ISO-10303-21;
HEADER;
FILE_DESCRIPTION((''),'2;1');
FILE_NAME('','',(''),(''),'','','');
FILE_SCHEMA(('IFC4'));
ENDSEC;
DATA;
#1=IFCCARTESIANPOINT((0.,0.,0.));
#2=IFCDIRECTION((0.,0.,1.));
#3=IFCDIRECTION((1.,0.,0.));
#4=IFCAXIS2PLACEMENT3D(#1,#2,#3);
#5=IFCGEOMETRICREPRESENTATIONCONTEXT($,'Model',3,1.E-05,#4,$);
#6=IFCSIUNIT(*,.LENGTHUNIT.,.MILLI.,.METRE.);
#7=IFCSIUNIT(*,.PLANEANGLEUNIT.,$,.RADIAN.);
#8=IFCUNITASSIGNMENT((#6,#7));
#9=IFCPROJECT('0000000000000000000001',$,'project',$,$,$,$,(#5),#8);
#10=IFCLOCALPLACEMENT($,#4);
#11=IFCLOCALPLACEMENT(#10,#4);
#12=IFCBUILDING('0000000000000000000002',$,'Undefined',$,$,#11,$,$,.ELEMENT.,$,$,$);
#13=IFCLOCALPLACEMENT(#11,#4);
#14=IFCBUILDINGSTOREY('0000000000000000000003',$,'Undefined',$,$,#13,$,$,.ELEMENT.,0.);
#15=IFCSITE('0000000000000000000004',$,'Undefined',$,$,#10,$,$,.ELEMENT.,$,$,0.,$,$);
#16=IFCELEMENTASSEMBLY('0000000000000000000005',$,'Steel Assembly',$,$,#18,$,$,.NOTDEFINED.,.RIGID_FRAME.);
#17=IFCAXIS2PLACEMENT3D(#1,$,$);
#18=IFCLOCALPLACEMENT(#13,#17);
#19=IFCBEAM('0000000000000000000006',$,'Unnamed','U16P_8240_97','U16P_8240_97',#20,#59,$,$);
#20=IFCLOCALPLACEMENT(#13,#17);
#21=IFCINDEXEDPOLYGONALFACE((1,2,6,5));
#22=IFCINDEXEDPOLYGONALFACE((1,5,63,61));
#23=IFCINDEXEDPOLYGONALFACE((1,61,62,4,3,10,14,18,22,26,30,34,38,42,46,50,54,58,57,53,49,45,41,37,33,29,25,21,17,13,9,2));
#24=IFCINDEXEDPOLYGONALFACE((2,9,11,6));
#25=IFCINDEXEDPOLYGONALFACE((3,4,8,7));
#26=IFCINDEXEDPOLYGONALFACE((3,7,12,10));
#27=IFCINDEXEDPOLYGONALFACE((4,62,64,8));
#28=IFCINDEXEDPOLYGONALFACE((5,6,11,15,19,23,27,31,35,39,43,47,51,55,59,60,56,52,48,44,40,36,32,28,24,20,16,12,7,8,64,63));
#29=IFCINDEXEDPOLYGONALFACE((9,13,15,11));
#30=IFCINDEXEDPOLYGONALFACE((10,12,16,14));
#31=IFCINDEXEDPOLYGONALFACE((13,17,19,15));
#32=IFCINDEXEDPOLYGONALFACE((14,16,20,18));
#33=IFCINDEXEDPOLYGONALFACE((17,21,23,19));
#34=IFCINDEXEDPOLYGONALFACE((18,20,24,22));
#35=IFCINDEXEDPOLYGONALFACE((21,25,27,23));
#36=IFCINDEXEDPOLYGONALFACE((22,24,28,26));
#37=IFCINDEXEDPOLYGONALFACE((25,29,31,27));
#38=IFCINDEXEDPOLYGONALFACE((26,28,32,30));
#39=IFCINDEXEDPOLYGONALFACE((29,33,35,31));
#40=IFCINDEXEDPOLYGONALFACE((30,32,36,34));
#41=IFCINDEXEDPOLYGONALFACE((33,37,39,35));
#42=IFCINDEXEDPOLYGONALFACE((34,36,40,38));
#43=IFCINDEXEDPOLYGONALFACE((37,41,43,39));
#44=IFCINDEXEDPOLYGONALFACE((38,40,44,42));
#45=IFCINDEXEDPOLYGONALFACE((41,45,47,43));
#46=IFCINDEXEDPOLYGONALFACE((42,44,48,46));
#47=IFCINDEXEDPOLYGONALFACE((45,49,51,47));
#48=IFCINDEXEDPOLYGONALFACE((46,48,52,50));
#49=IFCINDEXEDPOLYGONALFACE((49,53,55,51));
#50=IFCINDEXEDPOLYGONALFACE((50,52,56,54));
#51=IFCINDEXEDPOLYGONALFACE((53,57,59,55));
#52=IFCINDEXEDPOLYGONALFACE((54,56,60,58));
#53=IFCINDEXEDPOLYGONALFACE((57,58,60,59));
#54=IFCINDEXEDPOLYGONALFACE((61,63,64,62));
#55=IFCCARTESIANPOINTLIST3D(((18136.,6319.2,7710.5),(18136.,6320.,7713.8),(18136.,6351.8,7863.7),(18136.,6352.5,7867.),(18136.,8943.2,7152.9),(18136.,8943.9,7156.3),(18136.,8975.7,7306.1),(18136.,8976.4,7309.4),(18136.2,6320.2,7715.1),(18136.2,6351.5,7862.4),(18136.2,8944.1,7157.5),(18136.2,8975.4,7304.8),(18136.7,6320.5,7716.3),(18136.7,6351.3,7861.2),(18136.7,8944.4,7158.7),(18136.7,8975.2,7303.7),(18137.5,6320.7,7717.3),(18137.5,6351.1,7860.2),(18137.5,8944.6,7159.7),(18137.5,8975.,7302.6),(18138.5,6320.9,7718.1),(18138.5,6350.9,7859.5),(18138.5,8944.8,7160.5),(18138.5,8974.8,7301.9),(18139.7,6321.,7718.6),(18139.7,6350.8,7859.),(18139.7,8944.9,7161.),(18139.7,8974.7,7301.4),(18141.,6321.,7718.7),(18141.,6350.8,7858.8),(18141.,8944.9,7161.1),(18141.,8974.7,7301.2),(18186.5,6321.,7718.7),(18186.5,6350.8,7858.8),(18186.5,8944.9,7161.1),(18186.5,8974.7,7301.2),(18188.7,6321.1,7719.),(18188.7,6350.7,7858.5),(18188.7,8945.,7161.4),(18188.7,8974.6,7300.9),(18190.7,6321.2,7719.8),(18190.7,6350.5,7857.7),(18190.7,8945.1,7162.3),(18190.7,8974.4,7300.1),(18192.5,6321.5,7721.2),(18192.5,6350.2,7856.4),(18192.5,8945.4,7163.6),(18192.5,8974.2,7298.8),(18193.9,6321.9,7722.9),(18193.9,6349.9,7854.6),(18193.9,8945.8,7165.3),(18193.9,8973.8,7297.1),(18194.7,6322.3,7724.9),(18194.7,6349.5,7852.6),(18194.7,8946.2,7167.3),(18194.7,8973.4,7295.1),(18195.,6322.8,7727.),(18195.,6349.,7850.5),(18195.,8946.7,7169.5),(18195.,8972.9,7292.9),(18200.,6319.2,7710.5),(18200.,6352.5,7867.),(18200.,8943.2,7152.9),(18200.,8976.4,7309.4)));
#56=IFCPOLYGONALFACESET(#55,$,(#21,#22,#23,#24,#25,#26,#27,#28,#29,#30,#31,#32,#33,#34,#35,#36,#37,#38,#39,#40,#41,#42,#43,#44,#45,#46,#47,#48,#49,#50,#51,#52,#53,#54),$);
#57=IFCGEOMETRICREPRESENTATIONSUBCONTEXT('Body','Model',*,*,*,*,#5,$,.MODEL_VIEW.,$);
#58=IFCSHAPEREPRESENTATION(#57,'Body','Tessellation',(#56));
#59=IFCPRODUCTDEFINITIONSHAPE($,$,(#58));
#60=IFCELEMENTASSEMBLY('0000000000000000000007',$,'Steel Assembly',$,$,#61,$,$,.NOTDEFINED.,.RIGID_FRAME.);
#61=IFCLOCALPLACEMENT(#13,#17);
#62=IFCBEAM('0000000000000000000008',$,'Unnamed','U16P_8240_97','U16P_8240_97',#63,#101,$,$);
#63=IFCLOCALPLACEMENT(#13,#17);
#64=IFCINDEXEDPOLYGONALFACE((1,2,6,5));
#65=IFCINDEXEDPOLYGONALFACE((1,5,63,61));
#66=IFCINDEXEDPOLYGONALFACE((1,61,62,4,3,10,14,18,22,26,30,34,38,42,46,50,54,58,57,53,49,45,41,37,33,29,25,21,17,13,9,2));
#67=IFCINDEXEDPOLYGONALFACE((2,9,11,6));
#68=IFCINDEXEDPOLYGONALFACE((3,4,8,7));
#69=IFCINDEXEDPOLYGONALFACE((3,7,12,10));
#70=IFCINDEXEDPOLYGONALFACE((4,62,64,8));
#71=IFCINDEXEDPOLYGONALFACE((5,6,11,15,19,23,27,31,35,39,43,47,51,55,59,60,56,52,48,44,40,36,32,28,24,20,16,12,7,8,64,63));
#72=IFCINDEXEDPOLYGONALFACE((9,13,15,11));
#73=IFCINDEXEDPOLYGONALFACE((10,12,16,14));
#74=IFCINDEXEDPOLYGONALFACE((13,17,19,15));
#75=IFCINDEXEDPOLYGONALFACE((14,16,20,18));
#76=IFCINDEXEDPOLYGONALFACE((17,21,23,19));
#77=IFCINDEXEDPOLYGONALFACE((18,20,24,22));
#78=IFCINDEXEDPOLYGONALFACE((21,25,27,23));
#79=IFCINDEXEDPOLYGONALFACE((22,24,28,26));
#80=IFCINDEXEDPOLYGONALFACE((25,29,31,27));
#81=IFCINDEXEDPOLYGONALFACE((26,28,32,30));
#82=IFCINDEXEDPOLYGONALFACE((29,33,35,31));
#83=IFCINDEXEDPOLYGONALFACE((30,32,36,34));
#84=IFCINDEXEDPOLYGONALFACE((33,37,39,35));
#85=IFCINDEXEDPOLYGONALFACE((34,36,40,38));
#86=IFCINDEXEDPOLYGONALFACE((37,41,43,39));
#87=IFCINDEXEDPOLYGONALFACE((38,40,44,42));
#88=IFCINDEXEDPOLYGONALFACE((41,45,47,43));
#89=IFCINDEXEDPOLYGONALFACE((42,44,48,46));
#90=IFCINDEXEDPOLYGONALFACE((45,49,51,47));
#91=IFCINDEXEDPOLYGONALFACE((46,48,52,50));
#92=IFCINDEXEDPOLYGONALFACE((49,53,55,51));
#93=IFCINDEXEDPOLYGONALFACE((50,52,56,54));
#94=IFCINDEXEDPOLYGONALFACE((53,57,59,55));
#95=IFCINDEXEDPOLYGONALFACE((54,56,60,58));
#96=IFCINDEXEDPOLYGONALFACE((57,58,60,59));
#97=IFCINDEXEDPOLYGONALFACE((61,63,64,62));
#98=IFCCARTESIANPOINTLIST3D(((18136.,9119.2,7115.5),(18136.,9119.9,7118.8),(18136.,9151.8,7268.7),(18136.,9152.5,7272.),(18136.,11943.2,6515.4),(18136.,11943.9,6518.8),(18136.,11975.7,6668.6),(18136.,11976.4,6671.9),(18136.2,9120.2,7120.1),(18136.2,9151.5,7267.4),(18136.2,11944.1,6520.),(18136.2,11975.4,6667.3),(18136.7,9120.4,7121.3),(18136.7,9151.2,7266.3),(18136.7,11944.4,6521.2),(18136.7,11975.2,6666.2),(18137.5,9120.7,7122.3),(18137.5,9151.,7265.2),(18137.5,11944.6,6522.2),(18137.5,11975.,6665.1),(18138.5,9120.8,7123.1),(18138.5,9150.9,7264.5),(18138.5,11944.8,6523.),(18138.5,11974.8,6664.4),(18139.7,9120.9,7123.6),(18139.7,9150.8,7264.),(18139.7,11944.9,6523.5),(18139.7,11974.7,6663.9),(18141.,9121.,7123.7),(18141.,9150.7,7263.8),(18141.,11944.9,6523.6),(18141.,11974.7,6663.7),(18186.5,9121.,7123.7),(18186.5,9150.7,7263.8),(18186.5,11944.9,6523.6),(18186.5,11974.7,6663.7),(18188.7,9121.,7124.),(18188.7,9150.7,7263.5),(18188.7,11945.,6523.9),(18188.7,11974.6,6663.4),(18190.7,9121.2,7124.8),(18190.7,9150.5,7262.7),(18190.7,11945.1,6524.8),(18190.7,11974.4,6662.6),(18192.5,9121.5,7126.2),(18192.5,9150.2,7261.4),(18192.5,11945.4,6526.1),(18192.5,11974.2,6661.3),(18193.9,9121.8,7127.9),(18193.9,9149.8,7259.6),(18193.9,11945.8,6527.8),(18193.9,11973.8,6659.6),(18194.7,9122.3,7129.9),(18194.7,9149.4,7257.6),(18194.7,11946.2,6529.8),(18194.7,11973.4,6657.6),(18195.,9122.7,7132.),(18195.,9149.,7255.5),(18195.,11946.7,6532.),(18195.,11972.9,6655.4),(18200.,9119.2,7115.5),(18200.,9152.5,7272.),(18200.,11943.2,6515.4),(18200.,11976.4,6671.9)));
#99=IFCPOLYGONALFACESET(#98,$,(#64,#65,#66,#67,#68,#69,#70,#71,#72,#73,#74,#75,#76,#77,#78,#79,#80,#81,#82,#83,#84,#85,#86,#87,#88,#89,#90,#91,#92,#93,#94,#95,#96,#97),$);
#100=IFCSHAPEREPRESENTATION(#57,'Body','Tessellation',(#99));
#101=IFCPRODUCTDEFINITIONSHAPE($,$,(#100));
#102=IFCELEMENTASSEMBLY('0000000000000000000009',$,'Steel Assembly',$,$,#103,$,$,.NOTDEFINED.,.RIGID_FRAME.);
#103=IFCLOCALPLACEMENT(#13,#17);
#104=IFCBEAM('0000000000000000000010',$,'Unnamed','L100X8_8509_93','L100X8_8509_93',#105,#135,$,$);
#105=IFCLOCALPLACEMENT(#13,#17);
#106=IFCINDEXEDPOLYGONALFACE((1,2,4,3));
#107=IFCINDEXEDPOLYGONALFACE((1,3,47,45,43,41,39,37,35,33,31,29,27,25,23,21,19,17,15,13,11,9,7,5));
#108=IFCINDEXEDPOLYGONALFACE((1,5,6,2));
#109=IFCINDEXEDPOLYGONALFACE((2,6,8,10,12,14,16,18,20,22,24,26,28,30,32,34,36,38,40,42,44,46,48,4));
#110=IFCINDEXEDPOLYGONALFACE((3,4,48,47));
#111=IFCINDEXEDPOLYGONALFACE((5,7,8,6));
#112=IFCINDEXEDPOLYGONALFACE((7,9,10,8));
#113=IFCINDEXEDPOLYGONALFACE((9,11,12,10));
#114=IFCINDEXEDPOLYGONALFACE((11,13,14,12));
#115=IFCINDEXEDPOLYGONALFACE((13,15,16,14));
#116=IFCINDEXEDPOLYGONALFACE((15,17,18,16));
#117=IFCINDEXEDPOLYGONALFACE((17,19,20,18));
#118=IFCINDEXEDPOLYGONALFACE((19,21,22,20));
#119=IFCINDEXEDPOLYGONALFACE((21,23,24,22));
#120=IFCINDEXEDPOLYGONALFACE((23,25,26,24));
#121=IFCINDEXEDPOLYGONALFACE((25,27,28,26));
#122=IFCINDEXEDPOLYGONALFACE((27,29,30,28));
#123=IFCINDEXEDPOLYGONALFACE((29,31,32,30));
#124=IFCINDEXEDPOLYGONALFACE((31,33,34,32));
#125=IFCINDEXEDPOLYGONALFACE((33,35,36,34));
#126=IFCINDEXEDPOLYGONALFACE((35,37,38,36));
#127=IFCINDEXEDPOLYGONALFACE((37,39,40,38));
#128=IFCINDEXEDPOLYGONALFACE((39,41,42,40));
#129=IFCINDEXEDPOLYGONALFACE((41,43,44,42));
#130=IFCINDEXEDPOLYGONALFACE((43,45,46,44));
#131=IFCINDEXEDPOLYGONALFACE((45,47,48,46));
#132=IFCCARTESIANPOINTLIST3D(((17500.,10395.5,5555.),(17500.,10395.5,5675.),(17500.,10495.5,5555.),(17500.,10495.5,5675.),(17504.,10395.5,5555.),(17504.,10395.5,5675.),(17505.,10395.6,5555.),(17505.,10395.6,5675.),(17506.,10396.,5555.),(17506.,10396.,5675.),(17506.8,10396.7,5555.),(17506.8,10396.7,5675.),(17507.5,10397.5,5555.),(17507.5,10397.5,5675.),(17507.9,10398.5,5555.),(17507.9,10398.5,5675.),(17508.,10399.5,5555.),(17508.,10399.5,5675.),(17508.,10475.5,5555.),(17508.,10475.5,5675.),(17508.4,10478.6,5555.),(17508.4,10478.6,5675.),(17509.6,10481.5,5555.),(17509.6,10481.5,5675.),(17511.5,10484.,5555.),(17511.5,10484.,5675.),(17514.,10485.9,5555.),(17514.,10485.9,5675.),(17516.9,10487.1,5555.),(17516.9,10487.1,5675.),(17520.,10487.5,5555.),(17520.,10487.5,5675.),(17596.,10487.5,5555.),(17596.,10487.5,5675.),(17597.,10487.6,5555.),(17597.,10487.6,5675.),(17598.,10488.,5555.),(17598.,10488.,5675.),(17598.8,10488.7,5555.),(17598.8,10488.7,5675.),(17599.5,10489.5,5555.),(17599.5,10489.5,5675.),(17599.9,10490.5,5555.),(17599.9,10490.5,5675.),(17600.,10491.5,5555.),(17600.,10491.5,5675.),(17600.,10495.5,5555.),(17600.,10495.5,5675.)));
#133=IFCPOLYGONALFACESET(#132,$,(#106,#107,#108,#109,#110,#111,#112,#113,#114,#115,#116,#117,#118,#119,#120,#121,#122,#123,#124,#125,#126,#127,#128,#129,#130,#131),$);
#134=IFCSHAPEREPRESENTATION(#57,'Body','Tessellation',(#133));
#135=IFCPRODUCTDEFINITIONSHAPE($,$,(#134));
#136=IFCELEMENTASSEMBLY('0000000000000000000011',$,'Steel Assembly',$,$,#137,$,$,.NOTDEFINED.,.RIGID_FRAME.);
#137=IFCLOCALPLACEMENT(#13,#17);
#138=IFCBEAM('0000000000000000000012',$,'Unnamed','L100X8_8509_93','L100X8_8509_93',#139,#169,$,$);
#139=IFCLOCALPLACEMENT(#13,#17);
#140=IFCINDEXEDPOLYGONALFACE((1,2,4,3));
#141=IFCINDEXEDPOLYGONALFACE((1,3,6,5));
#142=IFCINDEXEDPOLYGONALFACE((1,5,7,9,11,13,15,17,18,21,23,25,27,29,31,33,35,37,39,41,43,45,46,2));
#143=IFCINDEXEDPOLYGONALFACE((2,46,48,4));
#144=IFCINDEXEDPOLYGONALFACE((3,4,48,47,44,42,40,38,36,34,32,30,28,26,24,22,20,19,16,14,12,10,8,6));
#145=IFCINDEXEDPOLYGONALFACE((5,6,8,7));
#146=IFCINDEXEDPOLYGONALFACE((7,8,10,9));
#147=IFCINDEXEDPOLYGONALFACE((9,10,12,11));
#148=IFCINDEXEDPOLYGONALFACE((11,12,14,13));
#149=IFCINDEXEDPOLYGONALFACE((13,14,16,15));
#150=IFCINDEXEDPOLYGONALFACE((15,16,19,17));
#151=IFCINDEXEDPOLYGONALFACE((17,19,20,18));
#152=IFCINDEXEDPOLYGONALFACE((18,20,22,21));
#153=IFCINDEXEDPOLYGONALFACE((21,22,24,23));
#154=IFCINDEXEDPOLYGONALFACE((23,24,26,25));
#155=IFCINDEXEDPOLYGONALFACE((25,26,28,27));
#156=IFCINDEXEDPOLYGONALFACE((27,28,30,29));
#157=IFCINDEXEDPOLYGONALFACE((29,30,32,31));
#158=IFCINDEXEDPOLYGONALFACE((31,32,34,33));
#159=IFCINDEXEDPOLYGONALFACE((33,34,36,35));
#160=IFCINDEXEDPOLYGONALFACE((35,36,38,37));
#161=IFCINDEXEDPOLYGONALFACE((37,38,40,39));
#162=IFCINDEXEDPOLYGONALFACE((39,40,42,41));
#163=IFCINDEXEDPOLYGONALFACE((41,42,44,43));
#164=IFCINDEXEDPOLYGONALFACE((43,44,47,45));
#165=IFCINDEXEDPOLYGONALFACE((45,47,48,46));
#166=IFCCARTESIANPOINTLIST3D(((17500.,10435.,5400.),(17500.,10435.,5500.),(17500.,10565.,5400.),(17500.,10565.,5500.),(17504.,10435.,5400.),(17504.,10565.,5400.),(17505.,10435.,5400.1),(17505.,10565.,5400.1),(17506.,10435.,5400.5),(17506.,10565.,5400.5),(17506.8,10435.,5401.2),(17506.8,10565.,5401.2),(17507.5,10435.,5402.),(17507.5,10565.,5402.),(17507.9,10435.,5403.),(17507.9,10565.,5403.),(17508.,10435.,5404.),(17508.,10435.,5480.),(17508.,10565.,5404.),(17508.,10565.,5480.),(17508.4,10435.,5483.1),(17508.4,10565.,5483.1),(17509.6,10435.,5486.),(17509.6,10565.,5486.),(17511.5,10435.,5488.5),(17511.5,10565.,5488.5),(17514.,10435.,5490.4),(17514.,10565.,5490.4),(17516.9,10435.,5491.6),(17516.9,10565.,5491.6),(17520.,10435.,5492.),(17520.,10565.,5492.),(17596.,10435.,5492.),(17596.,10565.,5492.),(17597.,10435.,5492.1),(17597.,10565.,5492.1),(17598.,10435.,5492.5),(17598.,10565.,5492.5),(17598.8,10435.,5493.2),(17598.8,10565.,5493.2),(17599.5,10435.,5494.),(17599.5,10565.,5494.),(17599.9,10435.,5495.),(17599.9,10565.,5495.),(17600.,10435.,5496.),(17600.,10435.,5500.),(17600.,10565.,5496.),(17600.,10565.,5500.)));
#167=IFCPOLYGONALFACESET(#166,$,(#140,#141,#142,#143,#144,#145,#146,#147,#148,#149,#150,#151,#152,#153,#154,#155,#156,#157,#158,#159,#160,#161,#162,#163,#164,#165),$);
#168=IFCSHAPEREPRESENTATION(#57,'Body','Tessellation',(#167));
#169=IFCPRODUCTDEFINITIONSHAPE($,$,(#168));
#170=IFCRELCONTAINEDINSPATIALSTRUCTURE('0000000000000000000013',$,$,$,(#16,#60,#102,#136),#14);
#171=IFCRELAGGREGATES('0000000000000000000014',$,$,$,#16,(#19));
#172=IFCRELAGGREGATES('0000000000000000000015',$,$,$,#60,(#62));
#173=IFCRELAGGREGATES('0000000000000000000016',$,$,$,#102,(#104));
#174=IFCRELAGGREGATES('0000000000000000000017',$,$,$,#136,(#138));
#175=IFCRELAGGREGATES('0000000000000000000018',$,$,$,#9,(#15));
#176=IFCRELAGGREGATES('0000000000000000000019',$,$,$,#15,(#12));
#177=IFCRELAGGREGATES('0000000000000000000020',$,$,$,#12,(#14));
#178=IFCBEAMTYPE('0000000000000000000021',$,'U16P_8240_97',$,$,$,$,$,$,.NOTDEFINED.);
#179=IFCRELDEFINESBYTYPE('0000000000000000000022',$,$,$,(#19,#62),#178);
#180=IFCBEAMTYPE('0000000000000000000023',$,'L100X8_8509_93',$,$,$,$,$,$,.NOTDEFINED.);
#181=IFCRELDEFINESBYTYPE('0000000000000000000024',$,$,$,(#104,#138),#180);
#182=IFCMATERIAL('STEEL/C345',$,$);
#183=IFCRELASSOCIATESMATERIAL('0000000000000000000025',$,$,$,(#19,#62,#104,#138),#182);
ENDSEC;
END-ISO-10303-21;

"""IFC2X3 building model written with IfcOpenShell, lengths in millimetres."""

from ifc_helpers import new_model, si_unit, frame, origin_with_axes, origin_2d_with_axis, place, context, subcontext, project, spatial, l_section, u_section, extrude, material, type_object, element, aggregate, save


model = new_model("IFC2X3")

# Units and contexts
model_context = context("Model", 3, precision=1e-05, world=origin_with_axes())
body_context = subcontext(model_context, "Body", "Model", "MODEL_VIEW")
ifc_project = project(units=[si_unit("LENGTHUNIT", "METRE", prefix="MILLI"), si_unit("PLANEANGLEUNIT", "RADIAN")], contexts=[model_context])

# Site, building, storey
site_placement = place(None, origin_with_axes())
site = spatial("IfcSite", under=ifc_project, at=site_placement, Name="Undefined", CompositionType="ELEMENT", RefElevation=0.0)
building_placement = place(site_placement, origin_with_axes())
building = spatial("IfcBuilding", under=site, at=building_placement, Name="Undefined", CompositionType="ELEMENT")
storey_placement = place(building_placement, origin_with_axes())
storey = spatial("IfcBuildingStorey", under=building, at=storey_placement, Name="Undefined", CompositionType="ELEMENT", Elevation=0.0)

# Element assemblies, beams
assembly_1_placement = place(storey_placement, origin_with_axes())
assembly_1 = element("IfcElementAssembly", 1, at=assembly_1_placement, inside=storey, Name="Steel Assembly", AssemblyPlace="NOTDEFINED", PredefinedType="RIGID_FRAME")
ifc_material = material(Name="STEEL/C345")
beam_type_1 = type_object("IfcBeamType", Name="U16P_8240_97", PredefinedType="NOTDEFINED")
beam_1_placement = place(assembly_1_placement, frame((18168.0, 6335.9, 7788.8), z_axis=(0.0, -0.207859, -0.978159), x_axis=(0.0, 0.978159, -0.207859)))
beam_1 = element("IfcBeam", 2, at=beam_1_placement, type_object=beam_type_1, material=ifc_material, Name="Unnamed", Description="U16P_8240_97", ObjectType="U16P_8240_97", context=body_context, shape_type="SweptSolid", body=[
    extrude(u_section(Depth=160.0, FlangeWidth=64.0, WebThickness=5.0, FlangeThickness=8.4, FilletRadius=8.5, EdgeRadius=5.0, at=origin_2d_with_axis()), frame((2682.5, 0.0, 0.0), z_axis=(-1.0, 0.0, 0.0), x_axis=(0.0, -1.0, 0.0)), (0.0, 0.0, 1.0), 2682.5),
])
aggregate(assembly_1, [beam_1])
assembly_2_placement = place(storey_placement, origin_with_axes())
assembly_2 = element("IfcElementAssembly", 3, at=assembly_2_placement, inside=storey, Name="Steel Assembly", AssemblyPlace="NOTDEFINED", PredefinedType="RIGID_FRAME")
beam_2_placement = place(assembly_2_placement, frame((18168.0, 9135.9, 7193.8), z_axis=(0.0, -0.207859, -0.978159), x_axis=(0.0, 0.978159, -0.207859)))
beam_2 = element("IfcBeam", 4, at=beam_2_placement, type_object=beam_type_1, material=ifc_material, Name="Unnamed", Description="U16P_8240_97", ObjectType="U16P_8240_97", context=body_context, shape_type="SweptSolid", body=[
    extrude(u_section(Depth=160.0, FlangeWidth=64.0, WebThickness=5.0, FlangeThickness=8.4, FilletRadius=8.5, EdgeRadius=5.0, at=origin_2d_with_axis()), frame((2887.0, 0.0, 0.0), z_axis=(-1.0, 0.0, 0.0), x_axis=(0.0, -1.0, 0.0)), (0.0, 0.0, 1.0), 2887.0),
])
aggregate(assembly_2, [beam_2])
assembly_3_placement = place(storey_placement, origin_with_axes())
assembly_3 = element("IfcElementAssembly", 5, at=assembly_3_placement, inside=storey, Name="Steel Assembly", AssemblyPlace="NOTDEFINED", PredefinedType="RIGID_FRAME")
beam_type_2 = type_object("IfcBeamType", Name="L100X8_8509_93", PredefinedType="NOTDEFINED")
beam_3_placement = place(assembly_3_placement, frame((17550.0, 10445.5, 5675.0), z_axis=(1.0, 0.0, 0.0), x_axis=(0.0, 0.0, -1.0)))
beam_3 = element("IfcBeam", 6, at=beam_3_placement, type_object=beam_type_2, material=ifc_material, Name="Unnamed", Description="L100X8_8509_93", ObjectType="L100X8_8509_93", context=body_context, shape_type="SweptSolid", body=[
    extrude(l_section(Depth=100.0, Width=100.0, Thickness=8.0, FilletRadius=12.0, EdgeRadius=4.0, at=origin_2d_with_axis()), frame((120.0, 0.0, 0.0), z_axis=(-1.0, 0.0, 0.0), x_axis=(0.0, -1.0, 0.0)), (0.0, 0.0, 1.0), 120.0),
])
aggregate(assembly_3, [beam_3])
assembly_4_placement = place(storey_placement, origin_with_axes())
assembly_4 = element("IfcElementAssembly", 7, at=assembly_4_placement, inside=storey, Name="Steel Assembly", AssemblyPlace="NOTDEFINED", PredefinedType="RIGID_FRAME")
beam_4_placement = place(assembly_4_placement, frame((17550.0, 10435.0, 5450.0), z_axis=(1.0, 0.0, 0.0), x_axis=(0.0, 1.0, 0.0)))
beam_4 = element("IfcBeam", 8, at=beam_4_placement, type_object=beam_type_2, material=ifc_material, Name="Unnamed", Description="L100X8_8509_93", ObjectType="L100X8_8509_93", context=body_context, shape_type="SweptSolid", body=[
    extrude(l_section(Depth=100.0, Width=100.0, Thickness=8.0, FilletRadius=12.0, EdgeRadius=4.0, at=origin_2d_with_axis()), frame((130.0, 0.0, 0.0), z_axis=(-1.0, 0.0, 0.0), x_axis=(0.0, -1.0, 0.0)), (0.0, 0.0, 1.0), 130.0),
])
aggregate(assembly_4, [beam_4])

save(model, "model.ifc")
